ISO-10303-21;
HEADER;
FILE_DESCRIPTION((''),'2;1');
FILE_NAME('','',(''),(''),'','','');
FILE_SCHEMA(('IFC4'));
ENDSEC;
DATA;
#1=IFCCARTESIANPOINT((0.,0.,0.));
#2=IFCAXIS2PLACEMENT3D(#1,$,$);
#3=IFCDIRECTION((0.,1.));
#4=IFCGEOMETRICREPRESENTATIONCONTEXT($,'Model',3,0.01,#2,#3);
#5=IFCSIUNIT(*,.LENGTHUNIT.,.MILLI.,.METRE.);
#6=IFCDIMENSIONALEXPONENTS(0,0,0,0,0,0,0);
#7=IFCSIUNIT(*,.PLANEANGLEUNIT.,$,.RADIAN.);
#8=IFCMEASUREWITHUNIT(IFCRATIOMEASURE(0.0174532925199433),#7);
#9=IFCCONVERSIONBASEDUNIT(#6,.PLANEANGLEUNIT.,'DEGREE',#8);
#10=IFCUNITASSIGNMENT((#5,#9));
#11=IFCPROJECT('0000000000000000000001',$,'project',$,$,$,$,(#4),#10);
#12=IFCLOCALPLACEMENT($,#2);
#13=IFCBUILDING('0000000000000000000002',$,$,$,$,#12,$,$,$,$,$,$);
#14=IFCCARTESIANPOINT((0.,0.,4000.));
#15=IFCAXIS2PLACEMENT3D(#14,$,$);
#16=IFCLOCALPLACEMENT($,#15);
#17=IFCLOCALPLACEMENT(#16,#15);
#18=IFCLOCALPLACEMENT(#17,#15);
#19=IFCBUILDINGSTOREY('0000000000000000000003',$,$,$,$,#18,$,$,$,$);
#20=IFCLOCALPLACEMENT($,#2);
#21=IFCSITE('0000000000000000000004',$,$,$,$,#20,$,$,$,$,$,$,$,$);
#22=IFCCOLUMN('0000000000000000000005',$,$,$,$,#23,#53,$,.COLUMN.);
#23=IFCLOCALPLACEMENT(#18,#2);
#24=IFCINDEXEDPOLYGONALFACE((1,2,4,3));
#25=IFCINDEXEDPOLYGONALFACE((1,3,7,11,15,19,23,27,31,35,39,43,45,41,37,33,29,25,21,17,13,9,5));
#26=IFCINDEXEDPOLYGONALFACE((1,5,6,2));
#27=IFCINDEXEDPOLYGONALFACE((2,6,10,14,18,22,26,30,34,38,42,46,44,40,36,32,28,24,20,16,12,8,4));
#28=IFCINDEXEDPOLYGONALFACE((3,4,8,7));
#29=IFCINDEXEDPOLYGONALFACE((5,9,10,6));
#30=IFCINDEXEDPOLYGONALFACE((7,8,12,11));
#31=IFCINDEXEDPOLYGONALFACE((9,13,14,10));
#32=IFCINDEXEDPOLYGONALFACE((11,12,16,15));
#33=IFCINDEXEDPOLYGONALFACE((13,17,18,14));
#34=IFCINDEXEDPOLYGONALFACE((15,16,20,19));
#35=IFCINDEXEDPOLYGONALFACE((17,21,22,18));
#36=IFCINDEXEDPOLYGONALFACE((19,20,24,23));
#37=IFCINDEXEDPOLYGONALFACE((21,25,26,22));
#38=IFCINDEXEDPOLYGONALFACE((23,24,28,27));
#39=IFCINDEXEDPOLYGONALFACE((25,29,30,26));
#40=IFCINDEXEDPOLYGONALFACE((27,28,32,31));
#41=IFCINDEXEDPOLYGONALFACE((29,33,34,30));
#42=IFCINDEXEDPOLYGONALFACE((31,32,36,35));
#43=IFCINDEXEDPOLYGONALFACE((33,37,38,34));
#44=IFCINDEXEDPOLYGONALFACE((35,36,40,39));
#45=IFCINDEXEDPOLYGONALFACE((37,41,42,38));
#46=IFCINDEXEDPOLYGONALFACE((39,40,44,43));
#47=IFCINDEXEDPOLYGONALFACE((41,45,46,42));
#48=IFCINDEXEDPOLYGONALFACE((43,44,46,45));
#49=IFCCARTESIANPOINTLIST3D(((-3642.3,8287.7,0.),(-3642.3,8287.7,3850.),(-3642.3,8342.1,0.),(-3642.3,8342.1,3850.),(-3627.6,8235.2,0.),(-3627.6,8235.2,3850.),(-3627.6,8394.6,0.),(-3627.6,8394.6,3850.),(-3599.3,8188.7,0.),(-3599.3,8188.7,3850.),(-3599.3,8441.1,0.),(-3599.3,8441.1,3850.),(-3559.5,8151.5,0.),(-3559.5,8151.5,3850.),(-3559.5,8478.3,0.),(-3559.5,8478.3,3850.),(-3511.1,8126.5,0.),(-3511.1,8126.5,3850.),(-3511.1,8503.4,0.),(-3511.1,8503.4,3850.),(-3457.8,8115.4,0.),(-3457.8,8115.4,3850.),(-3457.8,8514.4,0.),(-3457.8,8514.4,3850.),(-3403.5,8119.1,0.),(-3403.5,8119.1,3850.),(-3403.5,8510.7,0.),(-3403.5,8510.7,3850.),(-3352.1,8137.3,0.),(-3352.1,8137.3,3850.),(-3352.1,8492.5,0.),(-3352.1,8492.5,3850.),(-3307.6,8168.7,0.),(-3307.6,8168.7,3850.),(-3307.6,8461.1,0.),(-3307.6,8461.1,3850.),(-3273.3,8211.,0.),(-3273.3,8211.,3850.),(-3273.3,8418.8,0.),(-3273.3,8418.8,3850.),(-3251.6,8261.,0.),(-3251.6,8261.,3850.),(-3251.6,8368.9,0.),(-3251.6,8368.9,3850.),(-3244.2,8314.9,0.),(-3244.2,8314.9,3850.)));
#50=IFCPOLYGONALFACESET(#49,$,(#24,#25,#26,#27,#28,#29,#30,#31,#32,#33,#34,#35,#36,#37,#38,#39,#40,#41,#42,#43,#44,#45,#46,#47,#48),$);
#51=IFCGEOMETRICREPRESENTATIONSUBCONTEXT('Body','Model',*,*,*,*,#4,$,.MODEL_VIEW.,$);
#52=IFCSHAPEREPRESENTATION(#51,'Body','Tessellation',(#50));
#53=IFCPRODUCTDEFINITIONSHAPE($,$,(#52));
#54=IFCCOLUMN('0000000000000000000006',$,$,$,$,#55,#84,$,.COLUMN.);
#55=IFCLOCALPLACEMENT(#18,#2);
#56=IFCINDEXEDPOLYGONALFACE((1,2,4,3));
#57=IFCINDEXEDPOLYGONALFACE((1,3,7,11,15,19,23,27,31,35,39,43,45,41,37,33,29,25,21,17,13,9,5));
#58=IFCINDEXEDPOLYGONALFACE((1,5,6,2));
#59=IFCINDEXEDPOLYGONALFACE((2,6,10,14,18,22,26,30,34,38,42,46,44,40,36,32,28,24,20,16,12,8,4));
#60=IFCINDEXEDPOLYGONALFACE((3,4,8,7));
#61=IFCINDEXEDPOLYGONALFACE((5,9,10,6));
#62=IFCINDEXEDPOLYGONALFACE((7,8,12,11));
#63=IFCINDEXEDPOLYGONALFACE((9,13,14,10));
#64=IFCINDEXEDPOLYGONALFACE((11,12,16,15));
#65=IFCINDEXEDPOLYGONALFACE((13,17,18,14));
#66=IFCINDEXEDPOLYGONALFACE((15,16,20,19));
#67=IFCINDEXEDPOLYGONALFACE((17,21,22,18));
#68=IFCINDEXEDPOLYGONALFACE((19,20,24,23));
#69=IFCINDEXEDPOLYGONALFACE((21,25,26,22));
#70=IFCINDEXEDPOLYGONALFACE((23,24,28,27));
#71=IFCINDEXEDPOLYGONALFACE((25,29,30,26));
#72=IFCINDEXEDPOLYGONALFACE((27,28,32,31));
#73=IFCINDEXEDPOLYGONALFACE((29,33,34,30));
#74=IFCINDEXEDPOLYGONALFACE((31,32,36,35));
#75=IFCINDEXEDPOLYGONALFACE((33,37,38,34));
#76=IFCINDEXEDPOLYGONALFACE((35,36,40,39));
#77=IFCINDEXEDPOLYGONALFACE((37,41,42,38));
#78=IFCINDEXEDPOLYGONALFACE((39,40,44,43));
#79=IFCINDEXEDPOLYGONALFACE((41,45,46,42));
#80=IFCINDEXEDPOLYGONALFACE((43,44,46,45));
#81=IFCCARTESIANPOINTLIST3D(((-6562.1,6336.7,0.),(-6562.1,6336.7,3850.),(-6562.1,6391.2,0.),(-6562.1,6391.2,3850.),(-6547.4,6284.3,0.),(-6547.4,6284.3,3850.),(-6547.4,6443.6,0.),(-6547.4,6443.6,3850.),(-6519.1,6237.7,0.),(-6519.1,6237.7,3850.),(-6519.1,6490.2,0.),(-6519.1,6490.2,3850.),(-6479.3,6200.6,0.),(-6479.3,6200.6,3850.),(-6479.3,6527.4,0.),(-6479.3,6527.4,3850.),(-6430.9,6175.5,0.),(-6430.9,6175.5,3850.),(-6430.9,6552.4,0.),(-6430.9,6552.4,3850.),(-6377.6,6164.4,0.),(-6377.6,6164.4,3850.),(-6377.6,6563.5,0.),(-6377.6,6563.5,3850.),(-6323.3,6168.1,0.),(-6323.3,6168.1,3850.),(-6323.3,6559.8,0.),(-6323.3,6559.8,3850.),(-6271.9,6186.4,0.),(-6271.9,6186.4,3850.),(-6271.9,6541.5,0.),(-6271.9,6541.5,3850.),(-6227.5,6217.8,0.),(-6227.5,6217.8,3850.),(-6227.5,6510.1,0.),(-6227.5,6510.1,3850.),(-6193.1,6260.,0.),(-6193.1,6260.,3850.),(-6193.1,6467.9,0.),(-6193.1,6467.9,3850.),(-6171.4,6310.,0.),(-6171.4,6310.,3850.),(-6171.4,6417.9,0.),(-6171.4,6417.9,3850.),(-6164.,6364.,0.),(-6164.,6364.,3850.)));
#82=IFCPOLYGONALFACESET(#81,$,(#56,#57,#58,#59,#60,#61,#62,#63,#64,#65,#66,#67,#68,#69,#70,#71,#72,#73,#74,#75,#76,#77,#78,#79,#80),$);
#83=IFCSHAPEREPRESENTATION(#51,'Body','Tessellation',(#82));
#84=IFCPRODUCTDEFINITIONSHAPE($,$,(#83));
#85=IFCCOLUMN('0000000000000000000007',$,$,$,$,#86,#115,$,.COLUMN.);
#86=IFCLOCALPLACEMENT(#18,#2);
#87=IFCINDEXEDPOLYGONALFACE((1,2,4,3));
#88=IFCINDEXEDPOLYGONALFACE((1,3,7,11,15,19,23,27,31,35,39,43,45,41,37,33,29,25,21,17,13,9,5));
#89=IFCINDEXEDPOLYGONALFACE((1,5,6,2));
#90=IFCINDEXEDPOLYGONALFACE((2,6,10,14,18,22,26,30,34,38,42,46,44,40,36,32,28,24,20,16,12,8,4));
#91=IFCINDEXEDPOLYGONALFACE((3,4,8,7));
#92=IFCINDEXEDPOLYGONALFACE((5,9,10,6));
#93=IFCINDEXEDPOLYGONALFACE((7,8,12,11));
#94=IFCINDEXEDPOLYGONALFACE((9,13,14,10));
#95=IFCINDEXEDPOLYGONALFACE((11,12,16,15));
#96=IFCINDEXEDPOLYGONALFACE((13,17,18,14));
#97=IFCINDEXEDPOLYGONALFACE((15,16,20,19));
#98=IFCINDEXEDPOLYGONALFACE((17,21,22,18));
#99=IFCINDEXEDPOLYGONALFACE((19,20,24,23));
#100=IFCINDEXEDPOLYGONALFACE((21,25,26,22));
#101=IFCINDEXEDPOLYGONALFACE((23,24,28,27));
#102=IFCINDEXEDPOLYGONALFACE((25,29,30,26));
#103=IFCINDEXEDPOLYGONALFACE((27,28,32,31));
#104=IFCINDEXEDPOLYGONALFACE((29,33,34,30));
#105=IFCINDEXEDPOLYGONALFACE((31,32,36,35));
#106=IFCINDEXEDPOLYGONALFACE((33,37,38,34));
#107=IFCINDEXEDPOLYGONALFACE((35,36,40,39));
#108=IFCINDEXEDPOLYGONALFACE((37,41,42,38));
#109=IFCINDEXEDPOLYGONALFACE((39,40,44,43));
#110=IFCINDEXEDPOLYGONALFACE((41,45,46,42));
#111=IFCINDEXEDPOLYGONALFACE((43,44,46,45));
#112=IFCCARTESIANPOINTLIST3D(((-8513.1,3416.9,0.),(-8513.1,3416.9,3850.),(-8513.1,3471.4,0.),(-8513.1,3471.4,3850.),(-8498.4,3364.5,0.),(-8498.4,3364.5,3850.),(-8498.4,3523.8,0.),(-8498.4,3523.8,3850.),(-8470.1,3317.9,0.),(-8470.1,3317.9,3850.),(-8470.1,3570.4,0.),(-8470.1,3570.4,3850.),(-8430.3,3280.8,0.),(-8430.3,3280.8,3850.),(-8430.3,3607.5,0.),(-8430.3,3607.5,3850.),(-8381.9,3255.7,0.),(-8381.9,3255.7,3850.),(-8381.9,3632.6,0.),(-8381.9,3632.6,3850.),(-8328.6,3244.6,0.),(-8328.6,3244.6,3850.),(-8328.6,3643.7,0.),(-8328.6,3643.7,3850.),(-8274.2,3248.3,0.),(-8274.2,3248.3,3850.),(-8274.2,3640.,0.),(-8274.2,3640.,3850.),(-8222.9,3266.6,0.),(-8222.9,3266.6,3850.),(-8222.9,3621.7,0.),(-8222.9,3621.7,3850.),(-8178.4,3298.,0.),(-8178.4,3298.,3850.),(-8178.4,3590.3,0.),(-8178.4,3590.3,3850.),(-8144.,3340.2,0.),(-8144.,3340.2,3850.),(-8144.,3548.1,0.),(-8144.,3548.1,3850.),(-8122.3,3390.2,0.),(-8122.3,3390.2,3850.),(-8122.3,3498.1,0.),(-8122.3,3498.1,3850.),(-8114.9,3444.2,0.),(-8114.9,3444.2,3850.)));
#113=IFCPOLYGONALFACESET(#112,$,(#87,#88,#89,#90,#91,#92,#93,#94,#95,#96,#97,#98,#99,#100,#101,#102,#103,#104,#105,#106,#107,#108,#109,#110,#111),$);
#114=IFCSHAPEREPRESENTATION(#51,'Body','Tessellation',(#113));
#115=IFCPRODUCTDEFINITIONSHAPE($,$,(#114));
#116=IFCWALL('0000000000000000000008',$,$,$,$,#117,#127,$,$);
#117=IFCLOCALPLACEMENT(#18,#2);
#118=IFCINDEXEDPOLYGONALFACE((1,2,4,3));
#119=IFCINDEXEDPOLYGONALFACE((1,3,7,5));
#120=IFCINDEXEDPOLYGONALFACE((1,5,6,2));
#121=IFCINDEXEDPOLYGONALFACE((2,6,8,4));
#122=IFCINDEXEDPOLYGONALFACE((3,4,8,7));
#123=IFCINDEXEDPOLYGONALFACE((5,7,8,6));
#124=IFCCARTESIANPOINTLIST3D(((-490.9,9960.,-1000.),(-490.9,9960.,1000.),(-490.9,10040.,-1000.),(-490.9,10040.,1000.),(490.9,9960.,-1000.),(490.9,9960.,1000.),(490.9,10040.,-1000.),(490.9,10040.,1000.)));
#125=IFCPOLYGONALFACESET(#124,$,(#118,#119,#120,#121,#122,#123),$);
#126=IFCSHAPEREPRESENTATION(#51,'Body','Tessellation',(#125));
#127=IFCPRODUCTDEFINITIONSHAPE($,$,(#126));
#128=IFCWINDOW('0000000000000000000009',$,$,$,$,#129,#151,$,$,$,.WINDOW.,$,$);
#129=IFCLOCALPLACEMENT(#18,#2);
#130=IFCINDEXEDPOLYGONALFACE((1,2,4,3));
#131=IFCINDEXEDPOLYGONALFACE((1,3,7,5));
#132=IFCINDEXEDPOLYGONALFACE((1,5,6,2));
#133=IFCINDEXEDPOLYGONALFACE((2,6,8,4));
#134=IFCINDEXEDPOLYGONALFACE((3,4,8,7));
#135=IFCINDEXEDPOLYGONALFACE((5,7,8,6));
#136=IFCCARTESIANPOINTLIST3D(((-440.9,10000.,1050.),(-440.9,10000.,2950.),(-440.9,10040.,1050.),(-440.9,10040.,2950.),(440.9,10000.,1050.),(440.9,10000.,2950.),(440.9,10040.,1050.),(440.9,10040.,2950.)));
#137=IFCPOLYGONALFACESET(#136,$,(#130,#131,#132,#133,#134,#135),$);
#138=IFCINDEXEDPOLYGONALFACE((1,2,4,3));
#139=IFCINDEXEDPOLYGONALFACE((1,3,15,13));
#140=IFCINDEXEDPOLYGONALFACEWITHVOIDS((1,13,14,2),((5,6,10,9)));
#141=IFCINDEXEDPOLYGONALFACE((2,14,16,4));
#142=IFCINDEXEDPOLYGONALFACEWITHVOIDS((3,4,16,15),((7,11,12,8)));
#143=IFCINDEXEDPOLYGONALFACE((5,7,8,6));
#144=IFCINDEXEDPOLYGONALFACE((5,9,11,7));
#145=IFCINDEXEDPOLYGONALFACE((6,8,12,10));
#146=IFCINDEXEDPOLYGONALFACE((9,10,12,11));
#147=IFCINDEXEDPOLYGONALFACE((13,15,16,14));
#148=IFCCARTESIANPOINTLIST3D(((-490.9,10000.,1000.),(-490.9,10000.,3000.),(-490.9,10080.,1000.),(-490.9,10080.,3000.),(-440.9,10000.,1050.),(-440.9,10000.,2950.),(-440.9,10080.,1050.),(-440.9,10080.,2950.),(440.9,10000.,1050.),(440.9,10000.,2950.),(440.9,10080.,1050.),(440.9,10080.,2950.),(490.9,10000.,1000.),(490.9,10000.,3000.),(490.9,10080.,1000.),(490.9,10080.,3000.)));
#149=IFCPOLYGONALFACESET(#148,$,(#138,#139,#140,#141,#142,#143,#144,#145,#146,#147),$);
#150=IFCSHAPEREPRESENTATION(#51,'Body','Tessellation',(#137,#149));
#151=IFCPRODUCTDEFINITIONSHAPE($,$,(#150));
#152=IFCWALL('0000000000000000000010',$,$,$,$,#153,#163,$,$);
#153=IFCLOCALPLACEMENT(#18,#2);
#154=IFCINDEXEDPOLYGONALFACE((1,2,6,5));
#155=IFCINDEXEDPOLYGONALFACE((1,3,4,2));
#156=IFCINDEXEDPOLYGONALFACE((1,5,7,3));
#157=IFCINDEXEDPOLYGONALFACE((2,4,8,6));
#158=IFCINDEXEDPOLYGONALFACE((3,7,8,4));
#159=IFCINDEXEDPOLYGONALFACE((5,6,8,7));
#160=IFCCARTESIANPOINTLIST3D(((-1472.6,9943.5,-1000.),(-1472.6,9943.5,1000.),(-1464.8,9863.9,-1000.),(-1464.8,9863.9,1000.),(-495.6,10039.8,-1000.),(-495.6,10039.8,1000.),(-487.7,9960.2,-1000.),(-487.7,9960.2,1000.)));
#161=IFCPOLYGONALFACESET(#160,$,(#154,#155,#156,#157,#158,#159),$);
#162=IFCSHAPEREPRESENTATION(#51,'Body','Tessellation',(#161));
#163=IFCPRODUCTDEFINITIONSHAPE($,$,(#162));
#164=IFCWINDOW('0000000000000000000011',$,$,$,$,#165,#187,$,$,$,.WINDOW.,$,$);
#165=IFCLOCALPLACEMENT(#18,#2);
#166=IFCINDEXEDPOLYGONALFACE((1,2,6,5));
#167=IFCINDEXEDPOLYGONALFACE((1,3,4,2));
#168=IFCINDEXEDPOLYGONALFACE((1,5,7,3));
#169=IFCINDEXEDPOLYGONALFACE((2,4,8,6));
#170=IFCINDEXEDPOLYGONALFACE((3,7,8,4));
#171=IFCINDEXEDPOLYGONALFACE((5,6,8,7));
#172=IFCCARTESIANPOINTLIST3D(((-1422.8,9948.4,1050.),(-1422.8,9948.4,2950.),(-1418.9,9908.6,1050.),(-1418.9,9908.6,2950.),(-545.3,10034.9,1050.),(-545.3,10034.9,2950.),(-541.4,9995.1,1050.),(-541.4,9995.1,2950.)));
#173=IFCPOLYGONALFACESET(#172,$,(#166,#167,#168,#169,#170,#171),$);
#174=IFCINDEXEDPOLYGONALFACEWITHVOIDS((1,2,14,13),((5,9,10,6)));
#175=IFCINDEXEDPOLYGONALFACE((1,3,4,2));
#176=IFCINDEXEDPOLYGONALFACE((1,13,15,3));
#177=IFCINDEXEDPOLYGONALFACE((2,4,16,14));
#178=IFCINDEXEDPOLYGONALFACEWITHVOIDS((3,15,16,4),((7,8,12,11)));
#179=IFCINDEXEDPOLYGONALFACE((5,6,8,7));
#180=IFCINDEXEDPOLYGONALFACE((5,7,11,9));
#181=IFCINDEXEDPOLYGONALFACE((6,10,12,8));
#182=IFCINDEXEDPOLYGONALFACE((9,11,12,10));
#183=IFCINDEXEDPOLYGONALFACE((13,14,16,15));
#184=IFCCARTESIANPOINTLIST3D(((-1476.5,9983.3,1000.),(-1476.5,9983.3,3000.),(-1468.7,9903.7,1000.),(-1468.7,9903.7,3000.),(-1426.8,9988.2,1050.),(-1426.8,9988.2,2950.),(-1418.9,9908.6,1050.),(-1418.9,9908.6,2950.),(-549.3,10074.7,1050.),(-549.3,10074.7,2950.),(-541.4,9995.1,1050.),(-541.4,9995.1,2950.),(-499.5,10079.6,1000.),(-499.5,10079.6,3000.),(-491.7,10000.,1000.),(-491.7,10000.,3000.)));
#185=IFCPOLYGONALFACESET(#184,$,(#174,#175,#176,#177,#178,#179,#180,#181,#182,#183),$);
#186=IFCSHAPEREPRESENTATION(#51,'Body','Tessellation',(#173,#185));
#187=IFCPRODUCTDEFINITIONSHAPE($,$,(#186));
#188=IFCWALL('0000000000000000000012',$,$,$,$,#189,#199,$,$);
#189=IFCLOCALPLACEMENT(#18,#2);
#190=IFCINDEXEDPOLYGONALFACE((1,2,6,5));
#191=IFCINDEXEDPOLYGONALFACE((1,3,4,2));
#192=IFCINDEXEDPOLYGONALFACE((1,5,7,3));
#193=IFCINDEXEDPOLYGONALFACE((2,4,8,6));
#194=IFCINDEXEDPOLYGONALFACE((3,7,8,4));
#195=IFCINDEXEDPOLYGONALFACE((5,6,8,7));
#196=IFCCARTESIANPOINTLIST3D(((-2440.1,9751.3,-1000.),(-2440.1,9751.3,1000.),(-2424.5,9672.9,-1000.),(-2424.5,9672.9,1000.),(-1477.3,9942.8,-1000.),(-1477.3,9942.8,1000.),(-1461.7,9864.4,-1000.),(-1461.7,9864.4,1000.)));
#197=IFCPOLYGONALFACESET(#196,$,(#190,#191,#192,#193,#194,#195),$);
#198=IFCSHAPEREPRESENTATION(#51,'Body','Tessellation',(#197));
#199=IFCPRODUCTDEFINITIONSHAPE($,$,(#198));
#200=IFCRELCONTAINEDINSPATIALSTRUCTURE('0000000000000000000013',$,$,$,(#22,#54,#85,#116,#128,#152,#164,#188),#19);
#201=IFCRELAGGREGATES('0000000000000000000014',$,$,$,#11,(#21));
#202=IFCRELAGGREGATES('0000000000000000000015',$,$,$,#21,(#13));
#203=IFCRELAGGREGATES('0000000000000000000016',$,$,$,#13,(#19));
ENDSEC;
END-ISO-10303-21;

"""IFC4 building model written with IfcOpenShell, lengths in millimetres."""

from ifc_helpers import new_model, entity, si_unit, converted_unit, direction, frame, origin, origin_2d, place, context, subcontext, project, spatial, rectangle, circle, extrude, element, save


model = new_model("IFC4")

# Units and contexts
model_context = context("Model", 3, precision=0.01, world=origin(), true_north=direction((0.0, 1.0)))
body_context = subcontext(model_context, "Body", "Model", "MODEL_VIEW")
ifc_project = project(units=[si_unit("LENGTHUNIT", "METRE", prefix="MILLI"), converted_unit("PLANEANGLEUNIT", "DEGREE", entity("IfcRatioMeasure", 0.0174532925199433), si_unit("PLANEANGLEUNIT", "RADIAN"), dimensions=[0, 0, 0, 0, 0, 0, 0])], contexts=[model_context])

# Site, building, storey
site_placement = place(None, origin())
site = spatial("IfcSite", under=ifc_project, at=site_placement)
building_placement = place(None, origin())
building = spatial("IfcBuilding", under=site, at=building_placement)
placement_1 = place(None, frame((0.0, 0.0, 4000.0)))
placement_2 = place(placement_1, frame((0.0, 0.0, 4000.0)))
storey_placement = place(placement_2, frame((0.0, 0.0, 4000.0)))
storey = spatial("IfcBuildingStorey", under=building, at=storey_placement)

# Columns
for number, where in (
    (1, (-3444.2, 8314.9, 0.0)),
    (2, (-6364.0, 6364.0, 0.0)),
    (3, (-8314.9, 3444.2, 0.0)),
):
    element("IfcColumn", number, at=place(storey_placement, frame(where)), inside=storey, PredefinedType="COLUMN", context=body_context, shape_type="SweptSolid", body=[
        extrude(circle(Radius=200.0, at=origin_2d()), origin(), (0.0, 0.0, 1.0), 3850.0),
    ])

# Wall
wall_1_placement = place(storey_placement, frame((0.0, 10000.0, -1000.0), z_axis=(0.0, 0.0, 1.0), x_axis=(-10000.0, -0.000437, 0.0)))
element("IfcWall", 4, at=wall_1_placement, inside=storey, context=body_context, shape_type="SweptSolid", body=[
    extrude(rectangle(XDim=981.7, YDim=80.0, at=origin_2d()), origin(), (0.0, 0.0, 1.0), 2000.0),
])

# Window
cartesian_point_1 = entity("IfcCartesianPoint", [-440.9, -950.0])
shared_polyline = entity("IfcPolyline", [cartesian_point_1, entity("IfcCartesianPoint", [-440.9, 950.0]), entity("IfcCartesianPoint", [-440.9, 950.0]), entity("IfcCartesianPoint", [440.9, 950.0]), entity("IfcCartesianPoint", [440.9, 950.0]), entity("IfcCartesianPoint", [440.9, -950.0]), entity("IfcCartesianPoint", [440.9, -950.0]), entity("IfcCartesianPoint", [-440.9, -950.0]), cartesian_point_1])
window_1_placement = place(storey_placement, frame((0.0, 10000.0, 2000.0), z_axis=(0.0, 0.0, 1.0), x_axis=(-10000.0, -0.000437, 0.0)))
cartesian_point_2 = entity("IfcCartesianPoint", [-490.9, -1000.0])
element("IfcWindow", 5, at=window_1_placement, inside=storey, PredefinedType="WINDOW", context=body_context, shape_type="SweptSolid", body=[
    entity("IfcExtrudedAreaSolid", entity("IfcArbitraryClosedProfileDef", "AREA", None, shared_polyline), entity("IfcAxis2Placement3D", entity("IfcCartesianPoint", [0.0, 0.0, 0.0]), entity("IfcDirection", [0.0, -1.0, 0.0]), entity("IfcDirection", [1.0, 0.0, 0.0])), entity("IfcDirection", [0.0, 0.0, 1.0]), 40.0),
    entity("IfcExtrudedAreaSolid", entity("IfcArbitraryProfileDefWithVoids", "AREA", None, entity("IfcPolyline", [cartesian_point_2, entity("IfcCartesianPoint", [-490.9, 1000.0]), entity("IfcCartesianPoint", [-490.9, 1000.0]), entity("IfcCartesianPoint", [490.9, 1000.0]), entity("IfcCartesianPoint", [490.9, 1000.0]), entity("IfcCartesianPoint", [490.9, -1000.0]), entity("IfcCartesianPoint", [490.9, -1000.0]), entity("IfcCartesianPoint", [-490.9, -1000.0]), cartesian_point_2]), [shared_polyline]), entity("IfcAxis2Placement3D", entity("IfcCartesianPoint", [0.0, 0.0, 0.0]), entity("IfcDirection", [0.0, -1.0, 0.0]), entity("IfcDirection", [1.0, 0.0, 0.0])), entity("IfcDirection", [0.0, 0.0, 1.0]), 80.0),
])

# Wall
wall_2_placement = place(storey_placement, frame((-980.2, 9951.8, -1000.0), z_axis=(0.0, 0.0, 1.0), x_axis=(-9951.847302, -980.17105, 0.0)))
element("IfcWall", 6, at=wall_2_placement, inside=storey, context=body_context, shape_type="SweptSolid", body=[
    extrude(rectangle(XDim=981.7, YDim=80.0, at=origin_2d()), origin(), (0.0, 0.0, 1.0), 2000.0),
])

# Window
window_2_placement = place(storey_placement, frame((-980.2, 9951.8, 2000.0), z_axis=(0.0, 0.0, 1.0), x_axis=(-9951.847302, -980.17105, 0.0)))
cartesian_point_3 = entity("IfcCartesianPoint", [-490.9, -1000.0])
element("IfcWindow", 7, at=window_2_placement, inside=storey, PredefinedType="WINDOW", context=body_context, shape_type="SweptSolid", body=[
    entity("IfcExtrudedAreaSolid", entity("IfcArbitraryClosedProfileDef", "AREA", None, shared_polyline), entity("IfcAxis2Placement3D", entity("IfcCartesianPoint", [0.0, 0.0, 0.0]), entity("IfcDirection", [0.0, -1.0, 0.0]), entity("IfcDirection", [1.0, 0.0, 0.0])), entity("IfcDirection", [0.0, 0.0, 1.0]), 40.0),
    entity("IfcExtrudedAreaSolid", entity("IfcArbitraryProfileDefWithVoids", "AREA", None, entity("IfcPolyline", [cartesian_point_3, entity("IfcCartesianPoint", [-490.9, 1000.0]), entity("IfcCartesianPoint", [-490.9, 1000.0]), entity("IfcCartesianPoint", [490.9, 1000.0]), entity("IfcCartesianPoint", [490.9, 1000.0]), entity("IfcCartesianPoint", [490.9, -1000.0]), entity("IfcCartesianPoint", [490.9, -1000.0]), entity("IfcCartesianPoint", [-490.9, -1000.0]), cartesian_point_3]), [shared_polyline]), entity("IfcAxis2Placement3D", entity("IfcCartesianPoint", [0.0, 0.0, 0.0]), entity("IfcDirection", [0.0, -1.0, 0.0]), entity("IfcDirection", [1.0, 0.0, 0.0])), entity("IfcDirection", [0.0, 0.0, 1.0]), 80.0),
])

# Wall
wall_3_placement = place(storey_placement, frame((-1950.9, 9807.9, -1000.0), z_axis=(0.0, 0.0, 1.0), x_axis=(-9807.852795, -1950.903264, 0.0)))
element("IfcWall", 8, at=wall_3_placement, inside=storey, context=body_context, shape_type="SweptSolid", body=[
    extrude(rectangle(XDim=981.7, YDim=80.0, at=origin_2d()), origin(), (0.0, 0.0, 1.0), 2000.0),
])

save(model, "model.ifc")
